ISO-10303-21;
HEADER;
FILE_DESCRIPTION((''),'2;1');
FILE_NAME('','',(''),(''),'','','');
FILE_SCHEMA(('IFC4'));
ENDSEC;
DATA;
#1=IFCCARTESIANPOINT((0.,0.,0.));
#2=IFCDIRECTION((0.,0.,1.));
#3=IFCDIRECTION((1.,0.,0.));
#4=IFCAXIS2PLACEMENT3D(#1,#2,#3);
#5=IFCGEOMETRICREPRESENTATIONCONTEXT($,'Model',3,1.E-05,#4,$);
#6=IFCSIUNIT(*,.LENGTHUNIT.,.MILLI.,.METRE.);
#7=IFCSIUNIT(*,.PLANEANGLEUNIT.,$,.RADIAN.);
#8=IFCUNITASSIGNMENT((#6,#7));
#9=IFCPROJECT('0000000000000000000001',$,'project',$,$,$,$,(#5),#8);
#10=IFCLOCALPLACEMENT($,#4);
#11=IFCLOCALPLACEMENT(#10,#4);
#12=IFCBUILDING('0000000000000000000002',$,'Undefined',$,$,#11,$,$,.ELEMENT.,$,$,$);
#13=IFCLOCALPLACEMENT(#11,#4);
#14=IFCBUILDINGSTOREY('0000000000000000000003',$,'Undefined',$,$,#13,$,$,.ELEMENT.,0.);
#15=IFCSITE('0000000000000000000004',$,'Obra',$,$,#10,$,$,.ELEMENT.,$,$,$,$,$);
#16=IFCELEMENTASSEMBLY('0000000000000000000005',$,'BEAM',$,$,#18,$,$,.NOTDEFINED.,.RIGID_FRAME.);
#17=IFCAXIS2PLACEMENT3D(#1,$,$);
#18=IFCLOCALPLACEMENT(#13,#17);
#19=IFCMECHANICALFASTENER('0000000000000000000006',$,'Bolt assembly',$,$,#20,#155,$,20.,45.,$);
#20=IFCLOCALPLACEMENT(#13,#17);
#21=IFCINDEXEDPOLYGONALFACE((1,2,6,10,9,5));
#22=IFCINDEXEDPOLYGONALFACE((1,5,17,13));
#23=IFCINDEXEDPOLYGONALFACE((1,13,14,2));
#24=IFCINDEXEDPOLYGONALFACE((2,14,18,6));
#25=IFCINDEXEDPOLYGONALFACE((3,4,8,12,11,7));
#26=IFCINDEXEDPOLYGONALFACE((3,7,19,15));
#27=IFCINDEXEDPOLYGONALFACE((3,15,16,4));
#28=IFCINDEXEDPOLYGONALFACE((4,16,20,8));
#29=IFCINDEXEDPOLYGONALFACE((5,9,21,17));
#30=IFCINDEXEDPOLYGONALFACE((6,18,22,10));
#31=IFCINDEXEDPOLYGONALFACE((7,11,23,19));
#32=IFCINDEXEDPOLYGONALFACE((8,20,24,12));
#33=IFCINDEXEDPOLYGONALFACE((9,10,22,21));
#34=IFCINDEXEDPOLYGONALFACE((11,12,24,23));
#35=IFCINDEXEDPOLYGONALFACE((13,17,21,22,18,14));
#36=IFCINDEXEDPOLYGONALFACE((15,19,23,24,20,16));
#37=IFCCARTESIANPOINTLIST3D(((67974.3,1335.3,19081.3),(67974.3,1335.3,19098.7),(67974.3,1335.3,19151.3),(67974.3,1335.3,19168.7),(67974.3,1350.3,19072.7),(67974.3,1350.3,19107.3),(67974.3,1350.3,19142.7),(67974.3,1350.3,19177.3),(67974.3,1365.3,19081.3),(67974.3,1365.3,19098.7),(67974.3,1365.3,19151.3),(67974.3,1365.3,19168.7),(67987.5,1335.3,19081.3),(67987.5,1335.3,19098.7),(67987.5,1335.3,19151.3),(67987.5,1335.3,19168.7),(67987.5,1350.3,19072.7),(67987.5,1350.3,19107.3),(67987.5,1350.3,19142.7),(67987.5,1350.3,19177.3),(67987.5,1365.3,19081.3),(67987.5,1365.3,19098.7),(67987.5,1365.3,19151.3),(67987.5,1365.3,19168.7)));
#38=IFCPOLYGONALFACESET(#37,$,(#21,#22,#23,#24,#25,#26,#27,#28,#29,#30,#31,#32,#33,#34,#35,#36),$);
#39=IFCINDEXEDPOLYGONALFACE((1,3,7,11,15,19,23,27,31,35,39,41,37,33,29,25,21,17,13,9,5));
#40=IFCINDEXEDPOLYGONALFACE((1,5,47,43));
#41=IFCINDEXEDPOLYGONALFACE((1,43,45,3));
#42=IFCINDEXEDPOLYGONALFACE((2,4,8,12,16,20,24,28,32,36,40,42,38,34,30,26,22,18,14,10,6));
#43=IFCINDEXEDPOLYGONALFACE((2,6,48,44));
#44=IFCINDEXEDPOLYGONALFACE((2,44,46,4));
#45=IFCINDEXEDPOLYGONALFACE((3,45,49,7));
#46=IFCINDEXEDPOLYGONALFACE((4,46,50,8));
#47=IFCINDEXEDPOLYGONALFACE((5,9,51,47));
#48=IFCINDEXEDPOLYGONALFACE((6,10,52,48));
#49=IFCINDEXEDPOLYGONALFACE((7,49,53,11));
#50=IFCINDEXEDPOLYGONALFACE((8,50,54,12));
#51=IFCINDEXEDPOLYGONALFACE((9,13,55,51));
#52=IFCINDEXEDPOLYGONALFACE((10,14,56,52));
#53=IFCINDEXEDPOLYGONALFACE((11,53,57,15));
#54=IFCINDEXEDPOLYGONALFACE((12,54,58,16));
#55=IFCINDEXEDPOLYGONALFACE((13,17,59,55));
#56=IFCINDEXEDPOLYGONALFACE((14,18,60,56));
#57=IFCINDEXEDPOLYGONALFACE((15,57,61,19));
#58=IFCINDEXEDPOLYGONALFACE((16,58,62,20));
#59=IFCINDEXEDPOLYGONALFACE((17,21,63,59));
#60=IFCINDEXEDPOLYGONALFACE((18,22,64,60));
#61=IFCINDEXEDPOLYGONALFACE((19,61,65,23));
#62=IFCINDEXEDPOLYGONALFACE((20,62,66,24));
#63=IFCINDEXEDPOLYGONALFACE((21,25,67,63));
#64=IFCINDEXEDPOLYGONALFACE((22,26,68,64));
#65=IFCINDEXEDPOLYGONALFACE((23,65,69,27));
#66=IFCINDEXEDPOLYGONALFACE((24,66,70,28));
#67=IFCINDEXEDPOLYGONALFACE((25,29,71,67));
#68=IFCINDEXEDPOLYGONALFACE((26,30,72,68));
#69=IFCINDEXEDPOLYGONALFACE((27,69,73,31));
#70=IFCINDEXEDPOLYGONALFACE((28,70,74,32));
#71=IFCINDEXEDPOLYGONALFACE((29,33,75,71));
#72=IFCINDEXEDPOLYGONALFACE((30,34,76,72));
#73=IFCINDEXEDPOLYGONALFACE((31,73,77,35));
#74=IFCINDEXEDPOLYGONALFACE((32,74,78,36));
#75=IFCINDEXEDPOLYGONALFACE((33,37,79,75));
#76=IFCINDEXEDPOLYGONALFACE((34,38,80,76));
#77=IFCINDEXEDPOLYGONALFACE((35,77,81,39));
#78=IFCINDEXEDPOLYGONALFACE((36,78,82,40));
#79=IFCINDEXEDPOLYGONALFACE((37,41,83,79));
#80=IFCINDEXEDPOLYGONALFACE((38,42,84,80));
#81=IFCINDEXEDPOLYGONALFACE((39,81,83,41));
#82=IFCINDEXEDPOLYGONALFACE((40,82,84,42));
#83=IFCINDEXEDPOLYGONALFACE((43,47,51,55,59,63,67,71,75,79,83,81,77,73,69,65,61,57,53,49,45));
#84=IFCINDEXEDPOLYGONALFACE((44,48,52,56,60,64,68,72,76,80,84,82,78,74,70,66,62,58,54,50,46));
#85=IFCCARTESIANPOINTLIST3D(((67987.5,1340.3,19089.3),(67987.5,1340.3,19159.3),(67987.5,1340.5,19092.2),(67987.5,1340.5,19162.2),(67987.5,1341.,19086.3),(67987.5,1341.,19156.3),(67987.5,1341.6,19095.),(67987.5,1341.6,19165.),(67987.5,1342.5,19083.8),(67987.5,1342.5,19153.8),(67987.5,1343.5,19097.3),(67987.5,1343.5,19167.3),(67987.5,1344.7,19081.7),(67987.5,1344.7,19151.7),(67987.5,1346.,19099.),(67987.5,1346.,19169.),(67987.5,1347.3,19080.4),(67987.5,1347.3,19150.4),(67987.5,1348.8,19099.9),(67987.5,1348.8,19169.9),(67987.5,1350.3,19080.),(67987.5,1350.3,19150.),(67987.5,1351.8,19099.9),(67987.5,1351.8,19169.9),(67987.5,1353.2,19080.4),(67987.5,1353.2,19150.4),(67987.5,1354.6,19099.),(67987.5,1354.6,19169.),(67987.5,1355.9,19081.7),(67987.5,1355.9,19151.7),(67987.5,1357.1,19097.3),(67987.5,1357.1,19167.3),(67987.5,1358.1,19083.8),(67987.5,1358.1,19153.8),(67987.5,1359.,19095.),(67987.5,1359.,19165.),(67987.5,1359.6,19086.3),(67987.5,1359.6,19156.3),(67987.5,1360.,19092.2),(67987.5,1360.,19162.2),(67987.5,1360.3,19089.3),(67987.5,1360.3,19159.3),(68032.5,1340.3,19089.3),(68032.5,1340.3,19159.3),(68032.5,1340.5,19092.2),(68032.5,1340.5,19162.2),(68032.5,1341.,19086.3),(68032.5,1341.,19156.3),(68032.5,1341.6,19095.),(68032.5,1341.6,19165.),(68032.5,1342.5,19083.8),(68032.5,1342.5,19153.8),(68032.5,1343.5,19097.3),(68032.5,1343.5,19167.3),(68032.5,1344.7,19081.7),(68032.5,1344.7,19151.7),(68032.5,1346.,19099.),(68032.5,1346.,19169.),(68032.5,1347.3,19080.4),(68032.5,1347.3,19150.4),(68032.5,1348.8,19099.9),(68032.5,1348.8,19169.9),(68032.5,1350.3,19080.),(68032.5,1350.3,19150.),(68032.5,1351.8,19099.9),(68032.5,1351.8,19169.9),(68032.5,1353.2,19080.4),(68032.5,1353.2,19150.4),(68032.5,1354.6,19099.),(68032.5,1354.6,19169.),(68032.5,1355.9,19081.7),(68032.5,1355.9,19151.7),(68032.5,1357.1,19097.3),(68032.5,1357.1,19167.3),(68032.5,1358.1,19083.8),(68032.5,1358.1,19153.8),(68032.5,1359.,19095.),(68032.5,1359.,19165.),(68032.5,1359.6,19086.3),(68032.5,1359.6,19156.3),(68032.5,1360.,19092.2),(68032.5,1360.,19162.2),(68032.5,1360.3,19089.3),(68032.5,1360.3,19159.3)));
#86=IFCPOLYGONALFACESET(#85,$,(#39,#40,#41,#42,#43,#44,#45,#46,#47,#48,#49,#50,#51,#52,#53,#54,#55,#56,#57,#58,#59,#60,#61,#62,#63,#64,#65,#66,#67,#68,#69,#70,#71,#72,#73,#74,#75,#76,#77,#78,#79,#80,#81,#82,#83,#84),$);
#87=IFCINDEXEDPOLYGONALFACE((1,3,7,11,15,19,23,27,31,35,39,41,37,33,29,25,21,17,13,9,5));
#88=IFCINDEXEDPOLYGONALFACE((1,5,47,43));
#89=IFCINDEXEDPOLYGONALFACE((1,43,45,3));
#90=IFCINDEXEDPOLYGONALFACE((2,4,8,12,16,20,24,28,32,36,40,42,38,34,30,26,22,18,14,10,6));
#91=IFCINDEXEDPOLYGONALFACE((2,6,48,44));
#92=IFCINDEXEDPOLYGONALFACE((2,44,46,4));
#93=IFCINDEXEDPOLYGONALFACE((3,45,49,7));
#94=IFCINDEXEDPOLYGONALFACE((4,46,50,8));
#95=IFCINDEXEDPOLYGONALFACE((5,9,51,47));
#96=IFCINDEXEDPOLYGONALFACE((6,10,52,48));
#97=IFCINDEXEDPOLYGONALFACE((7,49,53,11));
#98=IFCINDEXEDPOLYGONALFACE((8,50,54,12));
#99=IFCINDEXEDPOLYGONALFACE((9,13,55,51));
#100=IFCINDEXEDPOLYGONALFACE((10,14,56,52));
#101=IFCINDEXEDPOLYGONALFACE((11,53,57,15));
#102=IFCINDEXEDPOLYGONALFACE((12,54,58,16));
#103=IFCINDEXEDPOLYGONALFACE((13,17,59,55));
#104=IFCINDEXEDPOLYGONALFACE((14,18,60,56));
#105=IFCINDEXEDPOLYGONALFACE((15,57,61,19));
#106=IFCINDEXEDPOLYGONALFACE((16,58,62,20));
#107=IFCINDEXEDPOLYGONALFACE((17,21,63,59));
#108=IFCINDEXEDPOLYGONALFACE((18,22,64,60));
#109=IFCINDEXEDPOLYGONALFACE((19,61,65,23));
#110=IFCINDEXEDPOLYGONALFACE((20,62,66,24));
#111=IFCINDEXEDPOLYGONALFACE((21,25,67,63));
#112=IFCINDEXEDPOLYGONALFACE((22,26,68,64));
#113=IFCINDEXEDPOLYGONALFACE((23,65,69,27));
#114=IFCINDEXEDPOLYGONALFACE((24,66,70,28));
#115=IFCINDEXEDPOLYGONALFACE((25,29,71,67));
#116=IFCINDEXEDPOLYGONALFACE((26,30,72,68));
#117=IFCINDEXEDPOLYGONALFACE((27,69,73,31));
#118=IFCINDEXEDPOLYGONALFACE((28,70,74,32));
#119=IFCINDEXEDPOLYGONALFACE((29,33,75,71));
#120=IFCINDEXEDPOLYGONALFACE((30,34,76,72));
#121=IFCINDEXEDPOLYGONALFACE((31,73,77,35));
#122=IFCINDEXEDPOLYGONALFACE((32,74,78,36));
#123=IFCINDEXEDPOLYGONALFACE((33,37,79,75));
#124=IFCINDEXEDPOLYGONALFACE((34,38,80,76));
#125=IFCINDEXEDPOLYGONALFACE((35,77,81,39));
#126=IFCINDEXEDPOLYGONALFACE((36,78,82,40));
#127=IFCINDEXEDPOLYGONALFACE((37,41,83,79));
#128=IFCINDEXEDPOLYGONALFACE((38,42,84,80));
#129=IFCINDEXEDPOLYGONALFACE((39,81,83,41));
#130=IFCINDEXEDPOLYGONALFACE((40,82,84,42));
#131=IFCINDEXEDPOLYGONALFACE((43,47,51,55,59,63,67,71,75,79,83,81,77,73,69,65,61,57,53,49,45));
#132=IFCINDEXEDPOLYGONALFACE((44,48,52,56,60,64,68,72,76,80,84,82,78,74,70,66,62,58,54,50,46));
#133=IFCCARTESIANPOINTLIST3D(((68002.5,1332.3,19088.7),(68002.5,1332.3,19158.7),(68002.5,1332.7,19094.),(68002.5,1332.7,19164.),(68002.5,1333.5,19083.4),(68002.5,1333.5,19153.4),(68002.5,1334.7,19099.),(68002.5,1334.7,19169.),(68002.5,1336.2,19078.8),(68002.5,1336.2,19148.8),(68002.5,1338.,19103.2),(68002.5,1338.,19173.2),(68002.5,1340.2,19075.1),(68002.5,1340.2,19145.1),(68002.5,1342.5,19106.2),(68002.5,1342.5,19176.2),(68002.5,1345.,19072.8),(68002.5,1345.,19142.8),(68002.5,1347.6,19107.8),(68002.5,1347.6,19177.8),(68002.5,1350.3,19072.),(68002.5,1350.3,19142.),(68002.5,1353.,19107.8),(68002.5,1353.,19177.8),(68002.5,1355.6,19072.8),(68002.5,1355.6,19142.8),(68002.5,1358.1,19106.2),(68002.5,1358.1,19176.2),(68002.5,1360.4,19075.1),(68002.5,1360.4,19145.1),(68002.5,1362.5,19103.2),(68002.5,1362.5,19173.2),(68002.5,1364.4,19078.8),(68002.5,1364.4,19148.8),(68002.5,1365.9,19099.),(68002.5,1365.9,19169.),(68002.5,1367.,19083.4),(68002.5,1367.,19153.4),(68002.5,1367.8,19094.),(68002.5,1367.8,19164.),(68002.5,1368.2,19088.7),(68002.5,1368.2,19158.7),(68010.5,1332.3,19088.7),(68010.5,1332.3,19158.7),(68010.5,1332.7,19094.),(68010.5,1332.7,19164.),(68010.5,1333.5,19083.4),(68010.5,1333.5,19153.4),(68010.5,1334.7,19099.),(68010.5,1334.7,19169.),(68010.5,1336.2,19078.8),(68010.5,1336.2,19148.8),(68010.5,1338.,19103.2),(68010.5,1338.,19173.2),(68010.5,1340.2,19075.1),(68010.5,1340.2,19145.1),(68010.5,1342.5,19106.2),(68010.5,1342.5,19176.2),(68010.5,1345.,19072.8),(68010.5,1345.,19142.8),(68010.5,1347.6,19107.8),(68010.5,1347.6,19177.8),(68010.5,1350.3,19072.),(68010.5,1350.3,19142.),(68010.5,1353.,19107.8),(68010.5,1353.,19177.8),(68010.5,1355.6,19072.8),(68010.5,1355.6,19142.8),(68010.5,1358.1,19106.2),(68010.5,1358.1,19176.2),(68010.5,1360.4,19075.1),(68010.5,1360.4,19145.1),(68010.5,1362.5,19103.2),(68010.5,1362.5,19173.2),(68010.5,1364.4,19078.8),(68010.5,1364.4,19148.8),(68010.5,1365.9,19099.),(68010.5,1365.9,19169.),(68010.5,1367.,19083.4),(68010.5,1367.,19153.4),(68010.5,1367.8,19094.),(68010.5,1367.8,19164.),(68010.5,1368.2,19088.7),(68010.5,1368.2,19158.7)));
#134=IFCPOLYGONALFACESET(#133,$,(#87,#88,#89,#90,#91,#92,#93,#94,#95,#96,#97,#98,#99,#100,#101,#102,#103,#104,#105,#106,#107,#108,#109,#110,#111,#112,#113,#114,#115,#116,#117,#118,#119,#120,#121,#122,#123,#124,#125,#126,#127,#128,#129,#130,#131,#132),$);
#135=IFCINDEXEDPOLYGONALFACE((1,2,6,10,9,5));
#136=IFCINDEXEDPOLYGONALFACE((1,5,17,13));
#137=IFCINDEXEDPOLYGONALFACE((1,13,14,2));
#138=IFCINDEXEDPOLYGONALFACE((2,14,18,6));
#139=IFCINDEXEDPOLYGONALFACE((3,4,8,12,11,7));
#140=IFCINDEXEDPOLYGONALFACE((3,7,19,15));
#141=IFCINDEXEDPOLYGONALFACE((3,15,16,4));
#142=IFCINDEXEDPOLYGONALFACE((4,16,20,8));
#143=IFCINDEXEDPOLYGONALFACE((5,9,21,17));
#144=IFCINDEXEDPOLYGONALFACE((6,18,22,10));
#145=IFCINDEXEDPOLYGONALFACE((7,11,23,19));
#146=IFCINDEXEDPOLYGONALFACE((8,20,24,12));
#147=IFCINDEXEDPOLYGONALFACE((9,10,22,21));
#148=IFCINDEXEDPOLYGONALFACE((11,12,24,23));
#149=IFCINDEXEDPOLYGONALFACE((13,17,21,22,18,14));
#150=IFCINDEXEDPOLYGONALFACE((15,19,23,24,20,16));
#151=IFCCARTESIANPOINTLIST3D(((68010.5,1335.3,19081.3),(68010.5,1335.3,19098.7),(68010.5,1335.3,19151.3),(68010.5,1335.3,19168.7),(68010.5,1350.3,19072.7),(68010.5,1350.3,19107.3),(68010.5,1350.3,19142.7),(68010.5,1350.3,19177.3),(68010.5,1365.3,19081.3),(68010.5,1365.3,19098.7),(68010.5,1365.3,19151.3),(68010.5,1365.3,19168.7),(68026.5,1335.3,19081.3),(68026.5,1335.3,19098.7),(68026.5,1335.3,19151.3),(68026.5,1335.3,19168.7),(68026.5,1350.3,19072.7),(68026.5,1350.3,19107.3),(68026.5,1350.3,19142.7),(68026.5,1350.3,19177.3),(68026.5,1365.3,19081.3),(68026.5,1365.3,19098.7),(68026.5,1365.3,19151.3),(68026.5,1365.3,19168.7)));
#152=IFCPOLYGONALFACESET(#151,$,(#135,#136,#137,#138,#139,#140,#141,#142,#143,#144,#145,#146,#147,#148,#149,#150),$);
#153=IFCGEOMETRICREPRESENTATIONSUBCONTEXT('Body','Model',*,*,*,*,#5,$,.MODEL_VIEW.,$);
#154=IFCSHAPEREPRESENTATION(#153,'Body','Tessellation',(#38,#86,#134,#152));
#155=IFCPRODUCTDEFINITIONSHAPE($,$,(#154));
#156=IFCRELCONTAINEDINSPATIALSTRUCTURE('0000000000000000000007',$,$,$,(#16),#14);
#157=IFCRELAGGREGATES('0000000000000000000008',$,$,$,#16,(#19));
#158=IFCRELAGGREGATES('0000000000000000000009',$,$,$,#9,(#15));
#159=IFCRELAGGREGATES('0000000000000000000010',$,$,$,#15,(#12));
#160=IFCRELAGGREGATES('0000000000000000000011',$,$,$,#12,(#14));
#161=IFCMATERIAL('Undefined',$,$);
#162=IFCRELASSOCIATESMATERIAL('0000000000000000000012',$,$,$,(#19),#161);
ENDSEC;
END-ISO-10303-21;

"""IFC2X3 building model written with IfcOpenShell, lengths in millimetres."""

from ifc_helpers import new_model, si_unit, frame, origin_with_axes, origin_2d_with_axis, place, context, subcontext, project, spatial, polyline, circle, outline, extrude, source, transform, mapped, material, element, aggregate, save


model = new_model("IFC2X3")

# Units and contexts
model_context = context("Model", 3, precision=1e-05, world=origin_with_axes())
body_context = subcontext(model_context, "Body", "Model", "MODEL_VIEW")
ifc_project = project(units=[si_unit("LENGTHUNIT", "METRE", prefix="MILLI"), si_unit("PLANEANGLEUNIT", "RADIAN")], contexts=[model_context])

# Site, building, storey
site_placement = place(None, origin_with_axes())
site = spatial("IfcSite", under=ifc_project, at=site_placement, Name="Obra", CompositionType="ELEMENT")
building_placement = place(site_placement, origin_with_axes())
building = spatial("IfcBuilding", under=site, at=building_placement, Name="Undefined", CompositionType="ELEMENT")
storey_placement = place(building_placement, origin_with_axes())
storey = spatial("IfcBuildingStorey", under=building, at=storey_placement, Name="Undefined", CompositionType="ELEMENT", Elevation=0.0)

# Shared definitions
ifc_material_1 = material(Name="Undefined")

# Element assembly
assembly_1_placement = place(storey_placement, origin_with_axes())
assembly_1 = element("IfcElementAssembly", 1, at=assembly_1_placement, inside=storey, Name="BEAM", AssemblyPlace="NOTDEFINED", PredefinedType="RIGID_FRAME")

# Mechanical fastener
shared_shape_1 = source(origin_with_axes(), body_context, "Body", "SweptSolid", [
    extrude(outline(polyline([(17.3, 0.0), (8.7, 15.0), (-8.7, 15.0), (-17.3, 0.0), (-8.7, -15.0), (8.7, -15.0), (17.3, 0.0)])), frame((0.0, -25.7, 0.0), z_axis=(0.0, 1.0, 0.0), x_axis=(1.0, 0.0, 0.0)), (0.0, 0.0, 1.0), 13.2),
    extrude(circle(Radius=10.0, at=origin_2d_with_axis()), frame((0.0, -12.5, 0.0), z_axis=(0.0, 1.0, 0.0), x_axis=(1.0, 0.0, 0.0)), (0.0, 0.0, 1.0), 45.0),
    extrude(circle(Radius=18.0, at=origin_2d_with_axis()), frame((0.0, 2.5, 0.0), z_axis=(0.0, 1.0, 0.0), x_axis=(1.0, 0.0, 0.0)), (0.0, 0.0, 1.0), 8.0),
    extrude(outline(polyline([(17.3, 0.0), (8.7, 15.0), (-8.7, 15.0), (-17.3, 0.0), (-8.7, -15.0), (8.7, -15.0), (17.3, 0.0)])), frame((0.0, 10.5, 0.0), z_axis=(0.0, 1.0, 0.0), x_axis=(1.0, 0.0, 0.0)), (0.0, 0.0, 1.0), 16.0),
])
mechanical_fastener_1_placement = place(assembly_1_placement, frame((68000.0, 1390.3, 19205.0), z_axis=(0.0, -1.0, 0.0), x_axis=(0.0, 0.0, -1.0)))
mechanical_fastener_1 = element("IfcMechanicalFastener", 2, at=mechanical_fastener_1_placement, material=ifc_material_1, Name="Bolt assembly", NominalDiameter=20.0, NominalLength=45.0, context=body_context, shape_type="MappedRepresentation", body=[
    mapped(shared_shape_1, transform((45.0, 0.0, 40.0))),
    mapped(shared_shape_1, transform((115.0, 0.0, 40.0))),
])
aggregate(assembly_1, [mechanical_fastener_1])

save(model, "model.ifc")
